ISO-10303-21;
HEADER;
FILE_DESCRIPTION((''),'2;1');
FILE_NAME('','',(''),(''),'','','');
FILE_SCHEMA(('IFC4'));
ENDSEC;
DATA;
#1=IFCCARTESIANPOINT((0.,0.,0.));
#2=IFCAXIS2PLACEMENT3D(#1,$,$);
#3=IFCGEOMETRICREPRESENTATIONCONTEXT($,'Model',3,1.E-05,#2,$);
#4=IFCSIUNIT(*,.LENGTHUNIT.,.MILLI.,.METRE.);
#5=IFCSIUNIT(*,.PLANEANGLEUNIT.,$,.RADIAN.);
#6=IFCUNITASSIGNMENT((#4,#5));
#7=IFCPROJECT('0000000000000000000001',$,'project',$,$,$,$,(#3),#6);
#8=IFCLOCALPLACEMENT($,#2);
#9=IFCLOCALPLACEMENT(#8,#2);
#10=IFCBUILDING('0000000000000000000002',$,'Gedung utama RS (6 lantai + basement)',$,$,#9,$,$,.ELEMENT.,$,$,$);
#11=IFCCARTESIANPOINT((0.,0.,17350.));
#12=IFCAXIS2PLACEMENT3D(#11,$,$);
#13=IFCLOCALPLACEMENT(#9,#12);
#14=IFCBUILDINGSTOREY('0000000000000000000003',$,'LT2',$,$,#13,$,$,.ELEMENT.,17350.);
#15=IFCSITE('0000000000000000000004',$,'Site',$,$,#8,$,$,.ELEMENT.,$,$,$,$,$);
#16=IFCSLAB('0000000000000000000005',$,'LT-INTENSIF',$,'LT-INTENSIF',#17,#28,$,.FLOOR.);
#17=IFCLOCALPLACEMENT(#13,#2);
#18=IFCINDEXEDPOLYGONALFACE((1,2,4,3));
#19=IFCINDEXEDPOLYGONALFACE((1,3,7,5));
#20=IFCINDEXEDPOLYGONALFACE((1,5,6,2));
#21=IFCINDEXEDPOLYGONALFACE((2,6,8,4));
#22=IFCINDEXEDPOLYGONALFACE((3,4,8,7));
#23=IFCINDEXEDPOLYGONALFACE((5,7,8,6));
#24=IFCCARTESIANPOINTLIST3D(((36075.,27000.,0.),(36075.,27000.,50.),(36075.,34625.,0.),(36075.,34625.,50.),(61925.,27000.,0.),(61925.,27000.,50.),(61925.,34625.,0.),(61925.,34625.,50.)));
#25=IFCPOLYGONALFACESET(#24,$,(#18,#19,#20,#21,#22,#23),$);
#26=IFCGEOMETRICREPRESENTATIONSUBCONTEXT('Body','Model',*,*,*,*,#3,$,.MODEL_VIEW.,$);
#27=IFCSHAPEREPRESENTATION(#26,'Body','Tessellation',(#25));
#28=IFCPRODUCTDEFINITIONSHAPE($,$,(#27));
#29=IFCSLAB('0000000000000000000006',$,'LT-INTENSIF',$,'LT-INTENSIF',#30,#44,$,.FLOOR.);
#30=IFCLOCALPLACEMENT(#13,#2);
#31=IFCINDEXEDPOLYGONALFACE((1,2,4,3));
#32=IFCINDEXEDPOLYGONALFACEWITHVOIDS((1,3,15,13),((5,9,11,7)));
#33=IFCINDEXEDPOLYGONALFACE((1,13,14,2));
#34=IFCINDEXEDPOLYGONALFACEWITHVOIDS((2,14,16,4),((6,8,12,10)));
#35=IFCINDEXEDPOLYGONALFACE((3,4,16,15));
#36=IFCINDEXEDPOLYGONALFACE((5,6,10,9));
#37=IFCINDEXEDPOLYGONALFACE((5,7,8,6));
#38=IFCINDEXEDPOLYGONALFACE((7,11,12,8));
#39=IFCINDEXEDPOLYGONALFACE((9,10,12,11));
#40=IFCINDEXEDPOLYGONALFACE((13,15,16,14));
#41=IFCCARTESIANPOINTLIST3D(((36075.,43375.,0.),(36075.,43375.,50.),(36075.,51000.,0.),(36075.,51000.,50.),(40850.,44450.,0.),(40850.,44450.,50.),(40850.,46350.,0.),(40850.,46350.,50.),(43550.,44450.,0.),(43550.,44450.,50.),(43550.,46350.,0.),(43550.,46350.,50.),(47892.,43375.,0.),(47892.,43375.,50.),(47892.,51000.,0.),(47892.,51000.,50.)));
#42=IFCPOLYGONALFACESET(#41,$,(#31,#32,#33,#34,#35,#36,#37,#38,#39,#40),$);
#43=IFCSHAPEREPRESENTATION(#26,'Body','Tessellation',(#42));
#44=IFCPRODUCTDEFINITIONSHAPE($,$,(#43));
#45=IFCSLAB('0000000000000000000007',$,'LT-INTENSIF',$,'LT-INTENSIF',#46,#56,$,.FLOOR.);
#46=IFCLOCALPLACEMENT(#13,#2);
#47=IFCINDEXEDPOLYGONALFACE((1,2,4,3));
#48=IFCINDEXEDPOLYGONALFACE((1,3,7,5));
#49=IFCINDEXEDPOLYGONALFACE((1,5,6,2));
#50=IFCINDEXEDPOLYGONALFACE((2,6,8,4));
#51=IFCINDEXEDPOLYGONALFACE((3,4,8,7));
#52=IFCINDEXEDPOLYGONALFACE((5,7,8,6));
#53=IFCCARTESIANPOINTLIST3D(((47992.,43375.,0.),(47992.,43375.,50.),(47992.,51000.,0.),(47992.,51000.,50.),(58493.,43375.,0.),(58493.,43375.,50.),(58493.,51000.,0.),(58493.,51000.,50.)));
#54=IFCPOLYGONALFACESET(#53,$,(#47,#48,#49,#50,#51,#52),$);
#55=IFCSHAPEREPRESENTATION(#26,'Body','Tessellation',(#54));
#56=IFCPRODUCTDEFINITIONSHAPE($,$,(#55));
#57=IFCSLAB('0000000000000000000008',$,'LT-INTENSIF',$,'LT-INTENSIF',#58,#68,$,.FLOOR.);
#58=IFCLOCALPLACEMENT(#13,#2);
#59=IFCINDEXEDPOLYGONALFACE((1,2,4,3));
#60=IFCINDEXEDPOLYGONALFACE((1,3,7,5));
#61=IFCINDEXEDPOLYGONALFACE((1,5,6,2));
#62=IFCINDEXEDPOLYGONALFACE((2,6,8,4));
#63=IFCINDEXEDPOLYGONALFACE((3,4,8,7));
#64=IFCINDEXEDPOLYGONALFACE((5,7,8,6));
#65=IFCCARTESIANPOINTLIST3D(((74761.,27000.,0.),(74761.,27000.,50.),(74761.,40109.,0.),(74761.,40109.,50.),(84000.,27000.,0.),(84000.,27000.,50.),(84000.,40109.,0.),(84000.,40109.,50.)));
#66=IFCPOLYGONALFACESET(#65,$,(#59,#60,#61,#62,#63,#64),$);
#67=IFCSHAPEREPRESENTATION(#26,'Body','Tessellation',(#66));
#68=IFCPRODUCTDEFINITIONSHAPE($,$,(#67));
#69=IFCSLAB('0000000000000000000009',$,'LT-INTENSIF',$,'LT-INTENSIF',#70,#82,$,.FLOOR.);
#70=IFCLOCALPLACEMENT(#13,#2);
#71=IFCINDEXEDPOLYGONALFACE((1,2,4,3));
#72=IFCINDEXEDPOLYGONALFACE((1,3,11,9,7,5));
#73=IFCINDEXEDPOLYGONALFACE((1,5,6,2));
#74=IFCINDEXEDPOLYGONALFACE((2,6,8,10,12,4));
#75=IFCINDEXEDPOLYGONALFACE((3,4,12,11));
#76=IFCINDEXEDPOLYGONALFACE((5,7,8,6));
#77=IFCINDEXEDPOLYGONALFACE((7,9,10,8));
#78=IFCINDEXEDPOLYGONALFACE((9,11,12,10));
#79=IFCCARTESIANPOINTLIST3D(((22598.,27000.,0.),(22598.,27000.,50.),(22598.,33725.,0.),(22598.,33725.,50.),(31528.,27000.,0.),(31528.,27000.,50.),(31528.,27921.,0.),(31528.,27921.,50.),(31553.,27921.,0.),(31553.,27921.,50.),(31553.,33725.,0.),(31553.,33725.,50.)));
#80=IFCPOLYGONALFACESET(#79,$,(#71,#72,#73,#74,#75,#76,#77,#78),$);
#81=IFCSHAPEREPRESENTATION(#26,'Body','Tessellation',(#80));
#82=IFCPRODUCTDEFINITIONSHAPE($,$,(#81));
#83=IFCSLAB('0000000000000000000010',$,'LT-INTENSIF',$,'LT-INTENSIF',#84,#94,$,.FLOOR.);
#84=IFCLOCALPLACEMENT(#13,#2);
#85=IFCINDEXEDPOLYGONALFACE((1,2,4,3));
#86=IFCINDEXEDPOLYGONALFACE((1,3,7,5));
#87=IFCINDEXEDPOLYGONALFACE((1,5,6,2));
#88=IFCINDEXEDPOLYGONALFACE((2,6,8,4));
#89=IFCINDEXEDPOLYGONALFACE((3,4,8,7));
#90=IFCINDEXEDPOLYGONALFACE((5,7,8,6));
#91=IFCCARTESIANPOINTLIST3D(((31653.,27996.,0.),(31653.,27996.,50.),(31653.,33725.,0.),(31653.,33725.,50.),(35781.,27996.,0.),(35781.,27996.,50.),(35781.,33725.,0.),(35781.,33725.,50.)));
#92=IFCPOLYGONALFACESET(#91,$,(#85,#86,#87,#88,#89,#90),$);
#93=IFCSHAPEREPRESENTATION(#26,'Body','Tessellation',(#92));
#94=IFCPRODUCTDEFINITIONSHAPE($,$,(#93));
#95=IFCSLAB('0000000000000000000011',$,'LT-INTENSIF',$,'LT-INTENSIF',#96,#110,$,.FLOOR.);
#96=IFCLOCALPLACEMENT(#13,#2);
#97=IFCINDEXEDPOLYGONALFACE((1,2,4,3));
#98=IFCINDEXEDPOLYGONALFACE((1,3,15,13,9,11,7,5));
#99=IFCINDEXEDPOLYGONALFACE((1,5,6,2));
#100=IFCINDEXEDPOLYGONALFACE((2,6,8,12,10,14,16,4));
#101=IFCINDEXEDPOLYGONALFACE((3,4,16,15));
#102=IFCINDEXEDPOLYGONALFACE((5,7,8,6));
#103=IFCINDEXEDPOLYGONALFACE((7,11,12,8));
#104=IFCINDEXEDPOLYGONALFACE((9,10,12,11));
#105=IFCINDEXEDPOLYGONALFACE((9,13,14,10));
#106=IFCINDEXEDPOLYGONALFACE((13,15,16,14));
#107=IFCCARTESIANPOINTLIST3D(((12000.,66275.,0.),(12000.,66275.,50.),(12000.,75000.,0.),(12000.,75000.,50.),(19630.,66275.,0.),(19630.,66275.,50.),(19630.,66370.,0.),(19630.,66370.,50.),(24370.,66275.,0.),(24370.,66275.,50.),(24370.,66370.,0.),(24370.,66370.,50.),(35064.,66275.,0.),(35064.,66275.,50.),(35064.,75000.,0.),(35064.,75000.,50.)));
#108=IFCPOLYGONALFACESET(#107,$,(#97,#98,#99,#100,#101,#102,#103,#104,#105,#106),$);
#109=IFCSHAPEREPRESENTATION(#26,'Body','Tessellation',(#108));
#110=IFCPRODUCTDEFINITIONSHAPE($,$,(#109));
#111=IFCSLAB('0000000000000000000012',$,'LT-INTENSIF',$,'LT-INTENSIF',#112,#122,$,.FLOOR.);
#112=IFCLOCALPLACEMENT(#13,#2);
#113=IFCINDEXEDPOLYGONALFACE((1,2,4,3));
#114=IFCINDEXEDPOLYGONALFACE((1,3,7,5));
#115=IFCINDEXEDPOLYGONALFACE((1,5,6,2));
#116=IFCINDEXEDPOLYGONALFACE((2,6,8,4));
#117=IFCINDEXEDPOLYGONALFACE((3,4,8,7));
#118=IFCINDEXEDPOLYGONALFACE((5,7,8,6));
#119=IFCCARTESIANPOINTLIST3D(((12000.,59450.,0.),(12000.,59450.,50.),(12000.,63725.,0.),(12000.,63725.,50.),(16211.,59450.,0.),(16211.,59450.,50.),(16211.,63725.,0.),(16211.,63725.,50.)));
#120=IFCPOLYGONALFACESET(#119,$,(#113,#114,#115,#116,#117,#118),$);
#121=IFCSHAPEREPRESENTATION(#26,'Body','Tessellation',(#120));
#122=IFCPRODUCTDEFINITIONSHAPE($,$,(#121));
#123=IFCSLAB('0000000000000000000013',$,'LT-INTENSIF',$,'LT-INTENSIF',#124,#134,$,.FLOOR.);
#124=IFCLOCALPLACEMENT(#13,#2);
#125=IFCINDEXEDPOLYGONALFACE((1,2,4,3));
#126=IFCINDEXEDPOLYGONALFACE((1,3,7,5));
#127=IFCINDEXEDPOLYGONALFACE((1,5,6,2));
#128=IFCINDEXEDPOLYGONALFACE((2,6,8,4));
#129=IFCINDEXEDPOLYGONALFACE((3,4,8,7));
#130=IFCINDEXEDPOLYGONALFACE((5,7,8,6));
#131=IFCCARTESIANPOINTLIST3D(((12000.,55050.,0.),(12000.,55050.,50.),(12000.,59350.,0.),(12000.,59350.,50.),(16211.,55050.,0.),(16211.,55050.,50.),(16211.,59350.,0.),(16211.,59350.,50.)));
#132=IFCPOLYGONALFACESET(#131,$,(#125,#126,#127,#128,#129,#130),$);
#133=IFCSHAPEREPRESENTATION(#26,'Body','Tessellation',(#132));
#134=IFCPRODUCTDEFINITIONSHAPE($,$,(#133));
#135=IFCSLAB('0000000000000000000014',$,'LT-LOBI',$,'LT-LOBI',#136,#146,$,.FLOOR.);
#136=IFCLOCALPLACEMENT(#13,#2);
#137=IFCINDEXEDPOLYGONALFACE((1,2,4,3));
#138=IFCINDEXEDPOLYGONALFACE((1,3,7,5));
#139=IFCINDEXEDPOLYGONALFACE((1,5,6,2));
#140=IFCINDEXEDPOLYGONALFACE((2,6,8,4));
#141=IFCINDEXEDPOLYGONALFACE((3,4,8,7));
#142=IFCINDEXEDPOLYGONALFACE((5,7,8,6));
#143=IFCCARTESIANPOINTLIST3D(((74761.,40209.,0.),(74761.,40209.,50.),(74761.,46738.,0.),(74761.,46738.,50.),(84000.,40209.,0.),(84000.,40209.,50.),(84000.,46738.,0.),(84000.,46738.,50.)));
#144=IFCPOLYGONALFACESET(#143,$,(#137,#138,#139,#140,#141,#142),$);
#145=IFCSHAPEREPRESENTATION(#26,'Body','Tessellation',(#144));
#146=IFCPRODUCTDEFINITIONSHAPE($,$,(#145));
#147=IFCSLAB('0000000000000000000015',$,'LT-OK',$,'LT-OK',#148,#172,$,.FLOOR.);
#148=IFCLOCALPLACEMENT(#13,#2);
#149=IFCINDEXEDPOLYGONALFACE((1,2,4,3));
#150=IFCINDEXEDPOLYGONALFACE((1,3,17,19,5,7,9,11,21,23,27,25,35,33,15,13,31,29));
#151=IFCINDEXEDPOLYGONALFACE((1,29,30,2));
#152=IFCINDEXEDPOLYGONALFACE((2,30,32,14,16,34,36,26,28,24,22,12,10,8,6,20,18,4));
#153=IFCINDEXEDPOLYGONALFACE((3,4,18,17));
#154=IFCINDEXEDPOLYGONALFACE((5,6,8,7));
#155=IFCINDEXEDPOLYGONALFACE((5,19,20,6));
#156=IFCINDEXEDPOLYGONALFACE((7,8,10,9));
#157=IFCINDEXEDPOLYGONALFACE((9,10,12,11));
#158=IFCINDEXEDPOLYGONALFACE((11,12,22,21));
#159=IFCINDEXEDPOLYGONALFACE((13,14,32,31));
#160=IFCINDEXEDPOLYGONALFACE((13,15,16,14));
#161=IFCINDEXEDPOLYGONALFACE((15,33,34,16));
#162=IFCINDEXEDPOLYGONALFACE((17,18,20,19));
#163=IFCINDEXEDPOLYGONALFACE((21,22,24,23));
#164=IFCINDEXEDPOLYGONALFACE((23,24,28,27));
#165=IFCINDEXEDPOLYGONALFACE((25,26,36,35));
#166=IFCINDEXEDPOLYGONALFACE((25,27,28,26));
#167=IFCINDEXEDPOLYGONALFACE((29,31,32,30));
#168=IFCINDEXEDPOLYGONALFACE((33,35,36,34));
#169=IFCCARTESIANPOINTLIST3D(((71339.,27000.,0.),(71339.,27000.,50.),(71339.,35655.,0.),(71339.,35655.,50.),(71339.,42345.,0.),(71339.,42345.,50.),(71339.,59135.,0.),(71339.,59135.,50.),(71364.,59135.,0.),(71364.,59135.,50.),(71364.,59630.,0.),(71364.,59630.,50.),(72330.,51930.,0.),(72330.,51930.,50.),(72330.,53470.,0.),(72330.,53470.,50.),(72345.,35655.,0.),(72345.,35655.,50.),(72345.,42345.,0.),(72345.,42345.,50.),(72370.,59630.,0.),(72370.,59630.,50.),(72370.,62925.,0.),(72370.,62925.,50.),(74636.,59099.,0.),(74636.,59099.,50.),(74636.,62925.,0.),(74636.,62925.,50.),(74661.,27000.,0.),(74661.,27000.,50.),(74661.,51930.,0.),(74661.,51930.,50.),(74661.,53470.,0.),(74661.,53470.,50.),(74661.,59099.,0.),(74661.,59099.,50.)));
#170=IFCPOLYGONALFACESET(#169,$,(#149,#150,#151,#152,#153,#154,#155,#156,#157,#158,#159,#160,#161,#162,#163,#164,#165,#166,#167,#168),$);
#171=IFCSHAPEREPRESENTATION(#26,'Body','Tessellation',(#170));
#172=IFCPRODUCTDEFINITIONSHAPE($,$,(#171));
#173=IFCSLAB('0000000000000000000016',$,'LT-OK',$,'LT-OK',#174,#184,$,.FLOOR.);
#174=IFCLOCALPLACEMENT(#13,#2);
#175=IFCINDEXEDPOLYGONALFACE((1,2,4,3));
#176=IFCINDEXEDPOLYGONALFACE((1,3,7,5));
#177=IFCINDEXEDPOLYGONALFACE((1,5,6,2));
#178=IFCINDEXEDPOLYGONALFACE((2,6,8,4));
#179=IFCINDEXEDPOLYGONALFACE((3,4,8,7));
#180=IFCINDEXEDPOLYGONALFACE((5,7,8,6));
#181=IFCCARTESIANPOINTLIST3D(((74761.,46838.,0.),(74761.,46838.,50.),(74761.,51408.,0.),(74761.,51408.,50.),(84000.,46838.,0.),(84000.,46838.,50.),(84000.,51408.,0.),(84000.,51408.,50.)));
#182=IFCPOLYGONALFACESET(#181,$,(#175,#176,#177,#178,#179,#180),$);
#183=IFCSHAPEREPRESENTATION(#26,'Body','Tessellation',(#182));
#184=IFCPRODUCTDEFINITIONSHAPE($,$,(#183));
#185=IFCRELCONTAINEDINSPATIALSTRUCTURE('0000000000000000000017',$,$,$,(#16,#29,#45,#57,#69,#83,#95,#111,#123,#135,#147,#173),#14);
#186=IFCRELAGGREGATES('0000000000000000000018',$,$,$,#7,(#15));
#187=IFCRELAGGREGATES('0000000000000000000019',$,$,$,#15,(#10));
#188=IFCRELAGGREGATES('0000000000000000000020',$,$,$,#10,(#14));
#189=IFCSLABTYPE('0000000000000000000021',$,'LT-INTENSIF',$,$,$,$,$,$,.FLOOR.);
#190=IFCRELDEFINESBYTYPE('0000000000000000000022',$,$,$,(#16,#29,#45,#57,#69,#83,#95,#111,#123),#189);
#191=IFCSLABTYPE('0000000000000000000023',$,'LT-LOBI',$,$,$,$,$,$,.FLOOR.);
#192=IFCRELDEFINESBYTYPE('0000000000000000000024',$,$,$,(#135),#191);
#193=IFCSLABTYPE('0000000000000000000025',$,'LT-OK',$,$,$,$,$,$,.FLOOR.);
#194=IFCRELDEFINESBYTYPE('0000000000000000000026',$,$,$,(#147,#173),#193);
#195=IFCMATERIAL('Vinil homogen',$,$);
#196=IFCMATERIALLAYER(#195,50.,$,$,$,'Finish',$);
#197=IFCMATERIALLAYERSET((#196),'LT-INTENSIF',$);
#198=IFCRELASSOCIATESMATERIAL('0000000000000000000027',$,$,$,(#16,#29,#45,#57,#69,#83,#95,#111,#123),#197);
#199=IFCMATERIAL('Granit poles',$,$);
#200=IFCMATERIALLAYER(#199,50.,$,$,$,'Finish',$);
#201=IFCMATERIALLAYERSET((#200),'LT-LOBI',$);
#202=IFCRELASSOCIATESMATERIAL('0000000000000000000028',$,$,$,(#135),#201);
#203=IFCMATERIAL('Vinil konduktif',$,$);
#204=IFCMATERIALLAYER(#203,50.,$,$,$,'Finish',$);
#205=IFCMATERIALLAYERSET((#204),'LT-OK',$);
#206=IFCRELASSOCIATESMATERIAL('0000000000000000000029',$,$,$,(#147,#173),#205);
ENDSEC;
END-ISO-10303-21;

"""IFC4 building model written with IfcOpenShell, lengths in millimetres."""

from ifc_helpers import new_model, si_unit, frame, origin, place, context, subcontext, project, spatial, polyline, outline, extrude, material, layer, layer_set, layer_usage, type_object, element, save


model = new_model("IFC4")

# Units and contexts
model_context = context("Model", 3, precision=1e-05, world=origin())
body_context = subcontext(model_context, "Body", "Model", "MODEL_VIEW")
ifc_project = project(units=[si_unit("LENGTHUNIT", "METRE", prefix="MILLI"), si_unit("PLANEANGLEUNIT", "RADIAN")], contexts=[model_context])

# Site, building, storey
site_placement = place(None, origin())
site = spatial("IfcSite", under=ifc_project, at=site_placement, Name="Site", CompositionType="ELEMENT")
building_placement = place(site_placement, origin())
building = spatial("IfcBuilding", under=site, at=building_placement, Name="Gedung utama RS (6 lantai + basement)", CompositionType="ELEMENT")
storey_placement = place(building_placement, frame((0.0, 0.0, 17350.0)))
storey = spatial("IfcBuildingStorey", under=building, at=storey_placement, Name="LT2", CompositionType="ELEMENT", Elevation=17350.0)

# Slabs
ifc_material_1 = material(Name="Vinil homogen")
ifc_layer_1 = layer(ifc_material_1, 50.0, Category="Finish")
ifc_layer_set_1 = layer_set([ifc_layer_1], Name="LT-INTENSIF")
ifc_layer_usage_1 = layer_usage(ifc_layer_set_1, "AXIS3", "NEGATIVE", 50.0)
slab_type_1 = type_object("IfcSlabType", Name="LT-INTENSIF", PredefinedType="FLOOR")
slab_1_placement = place(storey_placement, origin())
element("IfcSlab", 1, at=slab_1_placement, inside=storey, type_object=slab_type_1, material=ifc_layer_usage_1, Name="LT-INTENSIF", ObjectType="LT-INTENSIF", PredefinedType="FLOOR", context=body_context, shape_type="SweptSolid", body=[
    extrude(outline(polyline([(36075.0, 27000.0), (61925.0, 27000.0), (61925.0, 34625.0), (36075.0, 34625.0), (36075.0, 27000.0)])), origin(), (0.0, 0.0, 1.0), 50.0),
])
slab_2_placement = place(storey_placement, origin())
element("IfcSlab", 2, at=slab_2_placement, inside=storey, type_object=slab_type_1, material=ifc_layer_usage_1, Name="LT-INTENSIF", ObjectType="LT-INTENSIF", PredefinedType="FLOOR", context=body_context, shape_type="SweptSolid", body=[
    extrude(outline(polyline([(36075.0, 43375.0), (47892.0, 43375.0), (47892.0, 51000.0), (36075.0, 51000.0), (36075.0, 43375.0)]), holes=[polyline([(40850.0, 44450.0), (40850.0, 46350.0), (43550.0, 46350.0), (43550.0, 44450.0), (40850.0, 44450.0)])]), origin(), (0.0, 0.0, 1.0), 50.0),
])
slab_3_placement = place(storey_placement, origin())
element("IfcSlab", 3, at=slab_3_placement, inside=storey, type_object=slab_type_1, material=ifc_layer_usage_1, Name="LT-INTENSIF", ObjectType="LT-INTENSIF", PredefinedType="FLOOR", context=body_context, shape_type="SweptSolid", body=[
    extrude(outline(polyline([(47992.0, 43375.0), (58493.0, 43375.0), (58493.0, 51000.0), (47992.0, 51000.0), (47992.0, 43375.0)])), origin(), (0.0, 0.0, 1.0), 50.0),
])
slab_4_placement = place(storey_placement, origin())
element("IfcSlab", 4, at=slab_4_placement, inside=storey, type_object=slab_type_1, material=ifc_layer_usage_1, Name="LT-INTENSIF", ObjectType="LT-INTENSIF", PredefinedType="FLOOR", context=body_context, shape_type="SweptSolid", body=[
    extrude(outline(polyline([(74761.0, 27000.0), (84000.0, 27000.0), (84000.0, 40109.0), (74761.0, 40109.0), (74761.0, 27000.0)])), origin(), (0.0, 0.0, 1.0), 50.0),
])
slab_5_placement = place(storey_placement, origin())
element("IfcSlab", 5, at=slab_5_placement, inside=storey, type_object=slab_type_1, material=ifc_layer_usage_1, Name="LT-INTENSIF", ObjectType="LT-INTENSIF", PredefinedType="FLOOR", context=body_context, shape_type="SweptSolid", body=[
    extrude(outline(polyline([(22598.0, 27000.0), (31528.0, 27000.0), (31528.0, 27921.0), (31553.0, 27921.0), (31553.0, 33725.0), (22598.0, 33725.0), (22598.0, 27000.0)])), origin(), (0.0, 0.0, 1.0), 50.0),
])
slab_6_placement = place(storey_placement, origin())
element("IfcSlab", 6, at=slab_6_placement, inside=storey, type_object=slab_type_1, material=ifc_layer_usage_1, Name="LT-INTENSIF", ObjectType="LT-INTENSIF", PredefinedType="FLOOR", context=body_context, shape_type="SweptSolid", body=[
    extrude(outline(polyline([(31653.0, 27996.0), (35781.0, 27996.0), (35781.0, 33725.0), (31653.0, 33725.0), (31653.0, 27996.0)])), origin(), (0.0, 0.0, 1.0), 50.0),
])
slab_7_placement = place(storey_placement, origin())
element("IfcSlab", 7, at=slab_7_placement, inside=storey, type_object=slab_type_1, material=ifc_layer_usage_1, Name="LT-INTENSIF", ObjectType="LT-INTENSIF", PredefinedType="FLOOR", context=body_context, shape_type="SweptSolid", body=[
    extrude(outline(polyline([(12000.0, 66275.0), (19630.0, 66275.0), (19630.0, 66370.0), (24370.0, 66370.0), (24370.0, 66275.0), (35064.0, 66275.0), (35064.0, 75000.0), (12000.0, 75000.0), (12000.0, 66275.0)])), origin(), (0.0, 0.0, 1.0), 50.0),
])
slab_8_placement = place(storey_placement, origin())
element("IfcSlab", 8, at=slab_8_placement, inside=storey, type_object=slab_type_1, material=ifc_layer_usage_1, Name="LT-INTENSIF", ObjectType="LT-INTENSIF", PredefinedType="FLOOR", context=body_context, shape_type="SweptSolid", body=[
    extrude(outline(polyline([(12000.0, 59450.0), (16211.0, 59450.0), (16211.0, 63725.0), (12000.0, 63725.0), (12000.0, 59450.0)])), origin(), (0.0, 0.0, 1.0), 50.0),
])
slab_9_placement = place(storey_placement, origin())
element("IfcSlab", 9, at=slab_9_placement, inside=storey, type_object=slab_type_1, material=ifc_layer_usage_1, Name="LT-INTENSIF", ObjectType="LT-INTENSIF", PredefinedType="FLOOR", context=body_context, shape_type="SweptSolid", body=[
    extrude(outline(polyline([(12000.0, 55050.0), (16211.0, 55050.0), (16211.0, 59350.0), (12000.0, 59350.0), (12000.0, 55050.0)])), origin(), (0.0, 0.0, 1.0), 50.0),
])
ifc_material_2 = material(Name="Granit poles")
ifc_layer_2 = layer(ifc_material_2, 50.0, Category="Finish")
ifc_layer_set_2 = layer_set([ifc_layer_2], Name="LT-LOBI")
ifc_layer_usage_2 = layer_usage(ifc_layer_set_2, "AXIS3", "NEGATIVE", 50.0)
slab_type_2 = type_object("IfcSlabType", Name="LT-LOBI", PredefinedType="FLOOR")
slab_10_placement = place(storey_placement, origin())
element("IfcSlab", 10, at=slab_10_placement, inside=storey, type_object=slab_type_2, material=ifc_layer_usage_2, Name="LT-LOBI", ObjectType="LT-LOBI", PredefinedType="FLOOR", context=body_context, shape_type="SweptSolid", body=[
    extrude(outline(polyline([(74761.0, 40209.0), (84000.0, 40209.0), (84000.0, 46738.0), (74761.0, 46738.0), (74761.0, 40209.0)])), origin(), (0.0, 0.0, 1.0), 50.0),
])
ifc_material_3 = material(Name="Vinil konduktif")
ifc_layer_3 = layer(ifc_material_3, 50.0, Category="Finish")
ifc_layer_set_3 = layer_set([ifc_layer_3], Name="LT-OK")
ifc_layer_usage_3 = layer_usage(ifc_layer_set_3, "AXIS3", "NEGATIVE", 50.0)
slab_type_3 = type_object("IfcSlabType", Name="LT-OK", PredefinedType="FLOOR")
slab_11_placement = place(storey_placement, origin())
element("IfcSlab", 11, at=slab_11_placement, inside=storey, type_object=slab_type_3, material=ifc_layer_usage_3, Name="LT-OK", ObjectType="LT-OK", PredefinedType="FLOOR", context=body_context, shape_type="SweptSolid", body=[
    extrude(outline(polyline([(71339.0, 27000.0), (74661.0, 27000.0), (74661.0, 51930.0), (72330.0, 51930.0), (72330.0, 53470.0), (74661.0, 53470.0), (74661.0, 59099.0), (74636.0, 59099.0), (74636.0, 62925.0), (72370.0, 62925.0), (72370.0, 59630.0), (71364.0, 59630.0), (71364.0, 59135.0), (71339.0, 59135.0), (71339.0, 42345.0), (72345.0, 42345.0), (72345.0, 35655.0), (71339.0, 35655.0), (71339.0, 27000.0)])), origin(), (0.0, 0.0, 1.0), 50.0),
])
slab_12_placement = place(storey_placement, origin())
element("IfcSlab", 12, at=slab_12_placement, inside=storey, type_object=slab_type_3, material=ifc_layer_usage_3, Name="LT-OK", ObjectType="LT-OK", PredefinedType="FLOOR", context=body_context, shape_type="SweptSolid", body=[
    extrude(outline(polyline([(74761.0, 46838.0), (84000.0, 46838.0), (84000.0, 51408.0), (74761.0, 51408.0), (74761.0, 46838.0)])), origin(), (0.0, 0.0, 1.0), 50.0),
])

save(model, "model.ifc")
